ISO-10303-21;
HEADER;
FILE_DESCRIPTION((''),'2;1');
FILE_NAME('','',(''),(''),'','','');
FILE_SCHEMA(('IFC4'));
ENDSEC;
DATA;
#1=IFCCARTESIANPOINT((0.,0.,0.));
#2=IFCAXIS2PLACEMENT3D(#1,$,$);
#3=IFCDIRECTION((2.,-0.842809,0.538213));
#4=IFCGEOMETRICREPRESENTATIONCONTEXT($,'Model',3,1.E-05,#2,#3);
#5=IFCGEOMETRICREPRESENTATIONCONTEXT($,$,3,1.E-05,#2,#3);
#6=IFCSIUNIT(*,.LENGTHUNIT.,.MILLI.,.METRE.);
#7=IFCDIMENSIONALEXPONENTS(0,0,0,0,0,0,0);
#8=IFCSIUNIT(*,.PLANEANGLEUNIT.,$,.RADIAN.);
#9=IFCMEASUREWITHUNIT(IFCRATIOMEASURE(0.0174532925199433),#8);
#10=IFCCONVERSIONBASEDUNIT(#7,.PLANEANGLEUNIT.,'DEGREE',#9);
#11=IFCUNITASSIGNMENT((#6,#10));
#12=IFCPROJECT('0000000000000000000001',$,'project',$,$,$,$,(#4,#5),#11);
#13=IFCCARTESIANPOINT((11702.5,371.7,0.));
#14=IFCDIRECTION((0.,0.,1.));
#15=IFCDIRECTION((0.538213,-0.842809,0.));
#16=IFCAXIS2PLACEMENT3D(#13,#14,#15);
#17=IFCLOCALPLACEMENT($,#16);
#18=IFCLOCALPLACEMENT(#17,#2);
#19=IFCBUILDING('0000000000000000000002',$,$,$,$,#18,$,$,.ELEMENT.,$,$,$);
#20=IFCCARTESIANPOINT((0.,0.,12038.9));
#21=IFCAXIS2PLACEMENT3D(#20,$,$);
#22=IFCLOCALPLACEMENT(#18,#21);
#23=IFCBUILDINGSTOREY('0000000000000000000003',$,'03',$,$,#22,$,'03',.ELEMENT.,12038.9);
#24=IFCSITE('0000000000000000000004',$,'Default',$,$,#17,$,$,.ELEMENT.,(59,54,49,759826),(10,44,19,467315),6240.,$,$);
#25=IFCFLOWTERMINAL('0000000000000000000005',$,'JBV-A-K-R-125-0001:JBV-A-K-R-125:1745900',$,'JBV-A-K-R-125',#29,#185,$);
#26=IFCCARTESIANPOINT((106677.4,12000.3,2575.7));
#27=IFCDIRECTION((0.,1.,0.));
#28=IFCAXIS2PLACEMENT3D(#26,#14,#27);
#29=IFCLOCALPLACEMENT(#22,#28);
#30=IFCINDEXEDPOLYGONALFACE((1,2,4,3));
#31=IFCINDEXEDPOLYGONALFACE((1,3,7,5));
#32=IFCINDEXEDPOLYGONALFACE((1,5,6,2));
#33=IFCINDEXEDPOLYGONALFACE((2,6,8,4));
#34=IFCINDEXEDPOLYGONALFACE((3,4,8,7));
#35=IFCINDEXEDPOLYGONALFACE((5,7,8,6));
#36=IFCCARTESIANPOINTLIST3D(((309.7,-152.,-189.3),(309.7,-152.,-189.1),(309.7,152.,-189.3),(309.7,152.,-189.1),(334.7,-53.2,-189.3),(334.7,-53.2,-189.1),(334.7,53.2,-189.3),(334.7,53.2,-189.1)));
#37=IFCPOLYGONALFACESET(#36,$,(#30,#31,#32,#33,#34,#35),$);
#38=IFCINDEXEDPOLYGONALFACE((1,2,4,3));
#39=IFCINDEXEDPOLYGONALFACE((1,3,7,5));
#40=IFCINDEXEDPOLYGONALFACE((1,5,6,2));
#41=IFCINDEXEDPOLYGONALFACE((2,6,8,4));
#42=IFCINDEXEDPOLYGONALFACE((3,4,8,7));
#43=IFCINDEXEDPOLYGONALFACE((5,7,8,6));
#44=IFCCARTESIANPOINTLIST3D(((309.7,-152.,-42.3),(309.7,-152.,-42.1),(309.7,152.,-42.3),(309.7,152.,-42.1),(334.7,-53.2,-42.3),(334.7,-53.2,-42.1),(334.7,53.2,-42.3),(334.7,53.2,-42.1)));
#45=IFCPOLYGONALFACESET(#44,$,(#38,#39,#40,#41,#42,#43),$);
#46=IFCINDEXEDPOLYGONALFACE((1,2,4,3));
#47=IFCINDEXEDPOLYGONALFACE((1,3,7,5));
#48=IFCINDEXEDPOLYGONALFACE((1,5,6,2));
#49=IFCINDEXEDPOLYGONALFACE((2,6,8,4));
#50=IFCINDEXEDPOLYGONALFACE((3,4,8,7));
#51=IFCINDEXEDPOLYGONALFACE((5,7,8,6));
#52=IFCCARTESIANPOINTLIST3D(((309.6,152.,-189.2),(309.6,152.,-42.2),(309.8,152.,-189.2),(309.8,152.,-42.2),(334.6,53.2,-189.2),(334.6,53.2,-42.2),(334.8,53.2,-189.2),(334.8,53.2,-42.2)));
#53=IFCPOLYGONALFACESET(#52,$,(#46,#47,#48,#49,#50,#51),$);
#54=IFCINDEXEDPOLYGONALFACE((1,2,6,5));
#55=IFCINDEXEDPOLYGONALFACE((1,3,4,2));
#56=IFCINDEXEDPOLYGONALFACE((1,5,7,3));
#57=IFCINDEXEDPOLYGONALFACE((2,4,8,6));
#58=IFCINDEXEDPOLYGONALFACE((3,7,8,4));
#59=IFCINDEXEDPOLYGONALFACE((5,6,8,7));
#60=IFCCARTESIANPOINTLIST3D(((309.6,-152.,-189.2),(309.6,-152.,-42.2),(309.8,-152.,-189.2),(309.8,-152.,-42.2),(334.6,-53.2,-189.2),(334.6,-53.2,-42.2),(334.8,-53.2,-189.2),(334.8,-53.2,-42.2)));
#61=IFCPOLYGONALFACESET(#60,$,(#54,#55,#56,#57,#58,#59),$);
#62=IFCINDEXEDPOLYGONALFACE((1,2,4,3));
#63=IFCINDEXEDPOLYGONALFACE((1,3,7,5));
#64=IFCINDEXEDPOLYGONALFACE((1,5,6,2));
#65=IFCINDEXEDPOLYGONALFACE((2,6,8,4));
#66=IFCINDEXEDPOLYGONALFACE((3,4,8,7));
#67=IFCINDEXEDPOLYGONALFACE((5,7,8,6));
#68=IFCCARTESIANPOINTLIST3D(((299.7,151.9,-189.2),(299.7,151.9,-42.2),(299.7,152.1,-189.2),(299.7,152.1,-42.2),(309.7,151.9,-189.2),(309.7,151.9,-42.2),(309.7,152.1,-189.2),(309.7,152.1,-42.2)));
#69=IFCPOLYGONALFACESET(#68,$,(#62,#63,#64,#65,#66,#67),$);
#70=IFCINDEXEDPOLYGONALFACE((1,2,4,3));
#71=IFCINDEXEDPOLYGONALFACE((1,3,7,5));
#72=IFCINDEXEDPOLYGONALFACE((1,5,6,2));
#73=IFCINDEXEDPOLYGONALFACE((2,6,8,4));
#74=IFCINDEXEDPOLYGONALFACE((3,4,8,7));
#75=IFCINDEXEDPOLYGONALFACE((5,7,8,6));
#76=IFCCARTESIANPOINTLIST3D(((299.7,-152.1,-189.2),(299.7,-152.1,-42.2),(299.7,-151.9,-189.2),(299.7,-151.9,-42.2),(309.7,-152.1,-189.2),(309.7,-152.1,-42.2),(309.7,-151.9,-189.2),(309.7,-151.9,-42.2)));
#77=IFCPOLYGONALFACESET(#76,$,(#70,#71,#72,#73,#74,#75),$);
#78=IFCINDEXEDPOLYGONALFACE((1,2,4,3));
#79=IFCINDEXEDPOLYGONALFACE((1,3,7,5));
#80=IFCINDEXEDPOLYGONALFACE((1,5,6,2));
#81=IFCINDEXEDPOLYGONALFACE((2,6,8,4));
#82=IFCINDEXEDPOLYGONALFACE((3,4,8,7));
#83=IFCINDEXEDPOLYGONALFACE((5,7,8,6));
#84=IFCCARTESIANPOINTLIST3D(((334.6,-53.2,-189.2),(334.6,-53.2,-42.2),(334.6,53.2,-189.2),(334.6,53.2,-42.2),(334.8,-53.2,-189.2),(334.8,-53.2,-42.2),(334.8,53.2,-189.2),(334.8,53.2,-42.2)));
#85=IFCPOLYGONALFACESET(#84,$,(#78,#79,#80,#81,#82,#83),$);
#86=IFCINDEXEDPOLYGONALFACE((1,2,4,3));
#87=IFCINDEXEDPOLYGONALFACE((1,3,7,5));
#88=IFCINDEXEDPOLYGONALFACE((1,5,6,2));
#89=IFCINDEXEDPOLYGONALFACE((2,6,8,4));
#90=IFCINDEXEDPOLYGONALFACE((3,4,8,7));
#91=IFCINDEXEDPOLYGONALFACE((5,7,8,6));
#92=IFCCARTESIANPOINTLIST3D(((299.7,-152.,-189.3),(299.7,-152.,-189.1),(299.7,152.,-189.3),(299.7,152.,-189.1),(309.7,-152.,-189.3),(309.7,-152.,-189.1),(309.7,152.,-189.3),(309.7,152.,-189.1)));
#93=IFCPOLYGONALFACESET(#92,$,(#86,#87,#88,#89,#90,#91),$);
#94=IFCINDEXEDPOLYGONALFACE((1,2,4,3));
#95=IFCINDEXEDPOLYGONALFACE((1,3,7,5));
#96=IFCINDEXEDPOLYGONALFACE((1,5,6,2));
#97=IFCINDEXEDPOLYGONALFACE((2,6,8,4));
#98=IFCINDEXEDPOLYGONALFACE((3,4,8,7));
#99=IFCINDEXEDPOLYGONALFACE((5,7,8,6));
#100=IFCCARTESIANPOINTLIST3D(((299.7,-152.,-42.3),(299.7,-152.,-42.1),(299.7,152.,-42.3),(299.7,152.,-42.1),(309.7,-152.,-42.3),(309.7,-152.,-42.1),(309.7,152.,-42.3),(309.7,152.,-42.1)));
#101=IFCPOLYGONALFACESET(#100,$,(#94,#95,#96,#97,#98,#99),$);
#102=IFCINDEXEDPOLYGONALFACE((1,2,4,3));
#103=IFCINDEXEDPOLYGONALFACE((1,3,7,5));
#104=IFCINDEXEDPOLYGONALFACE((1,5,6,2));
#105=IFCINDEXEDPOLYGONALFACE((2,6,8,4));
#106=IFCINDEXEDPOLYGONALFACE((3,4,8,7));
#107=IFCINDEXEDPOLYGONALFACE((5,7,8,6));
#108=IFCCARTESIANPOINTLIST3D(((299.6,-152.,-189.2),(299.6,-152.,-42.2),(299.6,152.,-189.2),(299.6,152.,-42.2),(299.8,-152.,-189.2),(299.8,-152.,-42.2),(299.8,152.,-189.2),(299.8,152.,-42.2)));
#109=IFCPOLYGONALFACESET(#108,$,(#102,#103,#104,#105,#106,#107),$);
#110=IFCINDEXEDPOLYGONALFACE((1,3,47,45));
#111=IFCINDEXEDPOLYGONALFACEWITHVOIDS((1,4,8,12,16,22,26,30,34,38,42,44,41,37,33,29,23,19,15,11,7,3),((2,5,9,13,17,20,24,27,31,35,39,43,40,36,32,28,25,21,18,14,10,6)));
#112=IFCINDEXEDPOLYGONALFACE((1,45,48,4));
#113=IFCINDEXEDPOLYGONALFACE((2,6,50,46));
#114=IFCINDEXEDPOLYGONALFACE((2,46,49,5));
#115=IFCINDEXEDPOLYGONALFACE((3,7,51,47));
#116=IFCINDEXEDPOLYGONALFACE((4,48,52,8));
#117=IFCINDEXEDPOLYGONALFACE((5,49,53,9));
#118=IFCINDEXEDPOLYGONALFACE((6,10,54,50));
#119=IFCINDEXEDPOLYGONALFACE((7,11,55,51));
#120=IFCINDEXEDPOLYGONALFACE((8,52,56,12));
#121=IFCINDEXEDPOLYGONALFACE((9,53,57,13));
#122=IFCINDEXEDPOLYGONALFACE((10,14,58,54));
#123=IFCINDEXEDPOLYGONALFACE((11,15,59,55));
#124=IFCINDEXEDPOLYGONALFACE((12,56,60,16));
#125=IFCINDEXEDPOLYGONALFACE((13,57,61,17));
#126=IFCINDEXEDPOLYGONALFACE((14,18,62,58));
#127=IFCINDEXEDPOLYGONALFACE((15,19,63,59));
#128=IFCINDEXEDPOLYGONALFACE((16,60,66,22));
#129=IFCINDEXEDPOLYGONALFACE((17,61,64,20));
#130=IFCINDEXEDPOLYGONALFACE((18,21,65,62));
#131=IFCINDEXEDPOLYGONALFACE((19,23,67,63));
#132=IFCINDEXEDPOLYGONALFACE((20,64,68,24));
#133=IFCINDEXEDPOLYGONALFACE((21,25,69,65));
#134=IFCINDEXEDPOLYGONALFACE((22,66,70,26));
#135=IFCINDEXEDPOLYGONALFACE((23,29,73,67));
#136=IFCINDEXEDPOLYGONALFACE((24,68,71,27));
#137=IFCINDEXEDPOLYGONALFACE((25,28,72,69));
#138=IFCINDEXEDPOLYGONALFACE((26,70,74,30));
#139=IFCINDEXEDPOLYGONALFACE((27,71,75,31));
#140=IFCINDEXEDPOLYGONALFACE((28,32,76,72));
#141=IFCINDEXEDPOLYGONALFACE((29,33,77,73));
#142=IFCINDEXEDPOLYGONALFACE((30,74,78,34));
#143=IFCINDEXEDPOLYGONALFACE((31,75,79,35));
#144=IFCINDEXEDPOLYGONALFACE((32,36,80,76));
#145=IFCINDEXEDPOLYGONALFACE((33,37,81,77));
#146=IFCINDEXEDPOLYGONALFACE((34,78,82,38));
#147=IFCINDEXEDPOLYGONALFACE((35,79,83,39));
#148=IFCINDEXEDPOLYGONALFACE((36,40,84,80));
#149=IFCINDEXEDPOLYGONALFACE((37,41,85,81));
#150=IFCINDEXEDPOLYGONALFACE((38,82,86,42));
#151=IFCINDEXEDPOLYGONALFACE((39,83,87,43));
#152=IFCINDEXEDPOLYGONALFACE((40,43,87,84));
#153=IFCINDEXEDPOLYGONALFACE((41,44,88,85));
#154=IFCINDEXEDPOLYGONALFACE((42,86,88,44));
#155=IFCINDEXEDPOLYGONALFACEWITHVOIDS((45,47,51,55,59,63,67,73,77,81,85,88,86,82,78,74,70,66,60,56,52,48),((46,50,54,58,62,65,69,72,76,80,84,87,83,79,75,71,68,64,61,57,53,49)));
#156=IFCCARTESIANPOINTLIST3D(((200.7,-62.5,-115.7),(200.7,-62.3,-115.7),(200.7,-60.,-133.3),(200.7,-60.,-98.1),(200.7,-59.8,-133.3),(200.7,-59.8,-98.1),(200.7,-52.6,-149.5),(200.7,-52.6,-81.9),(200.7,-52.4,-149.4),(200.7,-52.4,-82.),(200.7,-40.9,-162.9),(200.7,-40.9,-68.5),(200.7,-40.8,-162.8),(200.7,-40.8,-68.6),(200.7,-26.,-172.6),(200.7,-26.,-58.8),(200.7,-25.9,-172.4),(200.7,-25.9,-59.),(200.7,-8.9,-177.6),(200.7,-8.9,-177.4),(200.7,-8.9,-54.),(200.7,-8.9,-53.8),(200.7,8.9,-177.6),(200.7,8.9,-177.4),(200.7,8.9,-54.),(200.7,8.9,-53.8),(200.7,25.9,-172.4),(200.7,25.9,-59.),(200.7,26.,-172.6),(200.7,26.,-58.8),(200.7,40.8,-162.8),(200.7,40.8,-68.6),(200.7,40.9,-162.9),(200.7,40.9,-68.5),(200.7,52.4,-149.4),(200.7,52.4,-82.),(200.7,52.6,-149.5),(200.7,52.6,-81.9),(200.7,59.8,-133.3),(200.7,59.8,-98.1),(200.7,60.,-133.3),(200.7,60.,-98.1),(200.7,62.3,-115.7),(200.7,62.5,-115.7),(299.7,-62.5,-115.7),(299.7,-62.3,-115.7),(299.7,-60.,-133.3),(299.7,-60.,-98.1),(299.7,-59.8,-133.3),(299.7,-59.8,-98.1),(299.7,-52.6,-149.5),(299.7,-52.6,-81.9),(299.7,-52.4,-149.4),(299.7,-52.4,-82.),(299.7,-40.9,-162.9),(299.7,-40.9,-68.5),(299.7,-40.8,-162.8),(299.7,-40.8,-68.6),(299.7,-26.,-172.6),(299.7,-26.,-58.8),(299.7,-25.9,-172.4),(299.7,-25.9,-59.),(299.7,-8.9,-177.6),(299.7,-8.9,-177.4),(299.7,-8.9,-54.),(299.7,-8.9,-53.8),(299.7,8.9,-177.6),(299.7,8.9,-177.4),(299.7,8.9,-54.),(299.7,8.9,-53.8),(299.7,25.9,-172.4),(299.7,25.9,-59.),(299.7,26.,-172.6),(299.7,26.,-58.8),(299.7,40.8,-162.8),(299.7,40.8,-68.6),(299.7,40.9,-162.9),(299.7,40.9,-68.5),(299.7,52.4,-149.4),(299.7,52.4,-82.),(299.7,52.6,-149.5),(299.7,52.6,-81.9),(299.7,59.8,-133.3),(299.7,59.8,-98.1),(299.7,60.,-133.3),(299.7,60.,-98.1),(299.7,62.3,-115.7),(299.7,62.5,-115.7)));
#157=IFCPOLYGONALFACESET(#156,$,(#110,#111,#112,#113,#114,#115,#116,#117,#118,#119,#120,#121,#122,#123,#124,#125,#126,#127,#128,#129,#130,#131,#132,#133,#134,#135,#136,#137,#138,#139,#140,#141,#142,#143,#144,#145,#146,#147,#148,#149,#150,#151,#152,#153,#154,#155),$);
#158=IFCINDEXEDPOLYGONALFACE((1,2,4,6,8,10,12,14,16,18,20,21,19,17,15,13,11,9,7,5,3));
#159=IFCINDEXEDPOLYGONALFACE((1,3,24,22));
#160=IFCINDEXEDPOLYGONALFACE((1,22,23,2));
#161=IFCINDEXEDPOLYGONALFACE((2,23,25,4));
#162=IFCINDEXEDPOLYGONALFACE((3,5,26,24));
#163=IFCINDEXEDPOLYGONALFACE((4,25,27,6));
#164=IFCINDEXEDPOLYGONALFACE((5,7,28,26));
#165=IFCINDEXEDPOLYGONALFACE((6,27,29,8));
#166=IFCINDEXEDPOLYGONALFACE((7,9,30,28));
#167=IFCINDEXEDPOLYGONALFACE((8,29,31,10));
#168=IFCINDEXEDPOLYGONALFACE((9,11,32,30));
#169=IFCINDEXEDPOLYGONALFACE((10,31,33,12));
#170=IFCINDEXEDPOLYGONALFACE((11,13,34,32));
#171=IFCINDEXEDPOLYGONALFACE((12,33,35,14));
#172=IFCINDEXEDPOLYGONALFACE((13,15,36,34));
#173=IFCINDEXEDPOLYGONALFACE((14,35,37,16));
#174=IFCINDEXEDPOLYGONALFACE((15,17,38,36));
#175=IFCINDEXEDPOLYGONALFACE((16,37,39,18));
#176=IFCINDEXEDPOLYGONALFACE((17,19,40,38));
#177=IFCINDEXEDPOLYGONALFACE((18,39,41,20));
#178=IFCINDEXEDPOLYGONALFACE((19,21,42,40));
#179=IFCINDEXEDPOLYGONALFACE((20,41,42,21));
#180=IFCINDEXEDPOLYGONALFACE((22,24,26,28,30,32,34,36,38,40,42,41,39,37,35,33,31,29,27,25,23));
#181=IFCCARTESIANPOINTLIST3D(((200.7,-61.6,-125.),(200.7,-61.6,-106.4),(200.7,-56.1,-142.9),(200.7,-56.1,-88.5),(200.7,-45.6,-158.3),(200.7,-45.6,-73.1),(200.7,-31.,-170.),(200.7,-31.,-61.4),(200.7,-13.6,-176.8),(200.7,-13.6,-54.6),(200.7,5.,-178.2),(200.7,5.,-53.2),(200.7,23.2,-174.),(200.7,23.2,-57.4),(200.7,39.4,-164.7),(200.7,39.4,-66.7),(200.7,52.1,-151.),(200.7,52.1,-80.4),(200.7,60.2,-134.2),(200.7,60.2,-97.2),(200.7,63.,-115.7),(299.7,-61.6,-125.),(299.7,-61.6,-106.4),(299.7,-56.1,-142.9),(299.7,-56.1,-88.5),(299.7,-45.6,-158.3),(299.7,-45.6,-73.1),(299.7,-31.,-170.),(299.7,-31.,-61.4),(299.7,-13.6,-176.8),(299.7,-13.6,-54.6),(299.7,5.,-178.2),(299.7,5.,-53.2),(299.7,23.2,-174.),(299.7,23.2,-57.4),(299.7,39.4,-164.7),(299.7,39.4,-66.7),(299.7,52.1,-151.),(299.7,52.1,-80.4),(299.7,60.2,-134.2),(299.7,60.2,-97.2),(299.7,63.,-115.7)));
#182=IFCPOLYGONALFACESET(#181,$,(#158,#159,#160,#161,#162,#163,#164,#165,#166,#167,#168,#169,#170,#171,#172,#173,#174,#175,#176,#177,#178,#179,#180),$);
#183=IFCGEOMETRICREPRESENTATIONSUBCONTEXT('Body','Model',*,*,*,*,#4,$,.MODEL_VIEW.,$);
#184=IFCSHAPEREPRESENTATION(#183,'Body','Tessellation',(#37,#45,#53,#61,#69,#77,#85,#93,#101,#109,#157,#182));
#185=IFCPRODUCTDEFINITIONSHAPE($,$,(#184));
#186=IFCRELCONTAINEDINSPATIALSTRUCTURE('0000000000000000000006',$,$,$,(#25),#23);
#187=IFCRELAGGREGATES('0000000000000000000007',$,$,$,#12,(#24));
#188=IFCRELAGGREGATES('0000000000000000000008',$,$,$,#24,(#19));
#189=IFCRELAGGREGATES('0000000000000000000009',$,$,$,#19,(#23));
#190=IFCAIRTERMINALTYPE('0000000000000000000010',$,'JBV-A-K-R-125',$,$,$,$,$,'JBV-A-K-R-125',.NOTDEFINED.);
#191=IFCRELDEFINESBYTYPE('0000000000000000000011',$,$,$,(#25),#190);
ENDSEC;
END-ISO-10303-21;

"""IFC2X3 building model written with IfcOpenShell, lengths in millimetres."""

from ifc_helpers import new_model, entity, si_unit, converted_unit, direction, frame, frame_2d, origin, origin_2d_with_axis, place, context, subcontext, project, spatial, polyline, circle_curve, parameter, trimmed, segment, composite_curve, rectangle, circle, outline, extrude, source, transform, mapped, type_object, type_shapes, element, save


model = new_model("IFC2X3")

# Units and contexts
model_context = context("Model", 3, precision=1e-05, world=origin(), true_north=direction((2.0, -0.842809, 0.538213)))
context_of_model = context(None, 3, precision=1e-05, world=origin(), true_north=direction((2.0, -0.842809, 0.538213)))
body_context = subcontext(model_context, "Body", "Model", "MODEL_VIEW")
ifc_project = project(units=[si_unit("LENGTHUNIT", "METRE", prefix="MILLI"), converted_unit("PLANEANGLEUNIT", "DEGREE", entity("IfcRatioMeasure", 0.0174532925199433), si_unit("PLANEANGLEUNIT", "RADIAN"), dimensions=[0, 0, 0, 0, 0, 0, 0])], contexts=[model_context, context_of_model])

# Site, building, storey
site_placement = place(None, frame((11702.5, 371.7, 0.0), z_axis=(0.0, 0.0, 1.0), x_axis=(0.538213, -0.842809, 0.0)))
site = spatial("IfcSite", under=ifc_project, at=site_placement, Name="Default", CompositionType="ELEMENT", RefLatitude=(59, 54, 49, 759826), RefLongitude=(10, 44, 19, 467315), RefElevation=6240.0)
building_placement = place(site_placement, origin())
building = spatial("IfcBuilding", under=site, at=building_placement, CompositionType="ELEMENT")
storey_placement = place(building_placement, frame((0.0, 0.0, 12038.9)))
storey = spatial("IfcBuildingStorey", under=building, at=storey_placement, Name="03", LongName="03", CompositionType="ELEMENT", Elevation=12038.9)

# Flow terminal
air_terminal_type_1 = type_object("IfcAirTerminalType", Name="JBV-A-K-R-125", ElementType="JBV-A-K-R-125", PredefinedType="NOTDEFINED")
shared_shape_1 = source(origin(), body_context, "Body", "SweptSolid", [
    extrude(outline(polyline([(-152.0, -12.5), (152.0, -12.5), (53.2, 12.5), (-53.2, 12.5), (-152.0, -12.5)])), frame((322.2, 0.0, -189.3), z_axis=(0.0, 0.0, 1.0), x_axis=(0.0, -1.0, 0.0)), (0.0, 0.0, 1.0), 0.2),
    extrude(outline(polyline([(-152.0, -12.5), (152.0, -12.5), (53.2, 12.5), (-53.2, 12.5), (-152.0, -12.5)])), frame((322.2, 0.0, -42.3), z_axis=(0.0, 0.0, 1.0), x_axis=(0.0, -1.0, 0.0)), (0.0, 0.0, 1.0), 0.2),
    extrude(rectangle(XDim=0.2, YDim=101.9, at=frame_2d((0.0, 0.0), x_axis=(1.0, 0.0))), frame((322.2, 102.6, -189.2), z_axis=(0.0, 0.0, 1.0), x_axis=(0.969446, 0.245305, 0.0)), (0.0, 0.0, 1.0), 147.0),
    extrude(rectangle(XDim=0.2, YDim=101.9, at=frame_2d((0.0, 0.0), x_axis=(1.0, 0.0))), frame((322.2, -102.6, -189.2), z_axis=(0.0, 0.0, 1.0), x_axis=(-0.969446, 0.245305, 0.0)), (0.0, 0.0, 1.0), 147.0),
    extrude(rectangle(XDim=0.2, YDim=10.0, at=frame_2d((0.0, 0.0), x_axis=(1.0, 0.0))), frame((304.7, 152.0, -189.2), z_axis=(0.0, 0.0, 1.0), x_axis=(0.0, 1.0, 0.0)), (0.0, 0.0, 1.0), 147.0),
    extrude(rectangle(XDim=0.2, YDim=10.0, at=frame_2d((0.0, 0.0), x_axis=(1.0, 0.0))), frame((304.7, -152.0, -189.2), z_axis=(0.0, 0.0, 1.0), x_axis=(0.0, 1.0, 0.0)), (0.0, 0.0, 1.0), 147.0),
    extrude(rectangle(XDim=0.2, YDim=106.4, at=frame_2d((0.0, 0.0), x_axis=(1.0, 0.0))), frame((334.7, 0.0, -189.2)), (0.0, 0.0, 1.0), 147.0),
    extrude(rectangle(XDim=304.0, YDim=10.0, at=frame_2d((0.0, 0.0), x_axis=(1.0, 0.0))), frame((304.7, 0.0, -189.3), z_axis=(0.0, 0.0, 1.0), x_axis=(0.0, -1.0, 0.0)), (0.0, 0.0, 1.0), 0.2),
    extrude(rectangle(XDim=304.0, YDim=10.0, at=frame_2d((0.0, 0.0), x_axis=(1.0, 0.0))), frame((304.7, 0.0, -42.3), z_axis=(0.0, 0.0, 1.0), x_axis=(0.0, -1.0, 0.0)), (0.0, 0.0, 1.0), 0.2),
    extrude(rectangle(XDim=0.2, YDim=304.0, at=frame_2d((0.0, 0.0), x_axis=(1.0, 0.0))), frame((299.7, 0.0, -189.2)), (0.0, 0.0, 1.0), 147.0),
    extrude(outline(composite_curve([segment(trimmed(circle_curve(origin_2d_with_axis(), 62.5), [parameter(0.0)], [parameter(180.0)], True, "PARAMETER"), True, "CONTINUOUS"), segment(trimmed(circle_curve(origin_2d_with_axis(), 62.5), [parameter(180.0)], [parameter(360.0)], True, "PARAMETER"), True, "CONTINUOUS")], self_intersect=False), holes=[composite_curve([segment(trimmed(circle_curve(origin_2d_with_axis(), 62.3), [parameter(180.0)], [parameter(360.0)], True, "PARAMETER"), False, "CONTINUOUS"), segment(trimmed(circle_curve(origin_2d_with_axis(), 62.3), [parameter(0.0)], [parameter(180.0)], True, "PARAMETER"), False, "CONTINUOUS")], self_intersect=False)]), frame((200.7, 0.0, -115.7), z_axis=(1.0, 0.0, 0.0), x_axis=(0.0, 1.0, 0.0)), (0.0, 0.0, 1.0), 99.0),
    extrude(circle(Radius=62.6, at=frame_2d((0.0, 0.0), x_axis=(1.0, 0.0))), frame((200.7, 0.3, -115.7), z_axis=(1.0, 0.0, 0.0), x_axis=(0.0, 1.0, 0.0)), (0.0, 0.0, 1.0), 99.0),
])
type_shapes(air_terminal_type_1, [shared_shape_1])
for number, where, z_axis, x_axis, name in (
    (1, (106677.4, 12000.3, 2575.7), (0.0, 0.0, 1.0), (0.0, 1.0, 0.0), "JBV-A-K-R-125-0001:JBV-A-K-R-125:1745900"),
):
    element("IfcFlowTerminal", number, at=place(storey_placement, frame(where, z_axis=z_axis, x_axis=x_axis)), inside=storey, type_object=air_terminal_type_1, Name=name, ObjectType="JBV-A-K-R-125", context=body_context, shape_type="MappedRepresentation", body=[
        mapped(shared_shape_1, transform((0.0, 0.0, 0.0), scale=1.0)),
    ])

save(model, "model.ifc")
